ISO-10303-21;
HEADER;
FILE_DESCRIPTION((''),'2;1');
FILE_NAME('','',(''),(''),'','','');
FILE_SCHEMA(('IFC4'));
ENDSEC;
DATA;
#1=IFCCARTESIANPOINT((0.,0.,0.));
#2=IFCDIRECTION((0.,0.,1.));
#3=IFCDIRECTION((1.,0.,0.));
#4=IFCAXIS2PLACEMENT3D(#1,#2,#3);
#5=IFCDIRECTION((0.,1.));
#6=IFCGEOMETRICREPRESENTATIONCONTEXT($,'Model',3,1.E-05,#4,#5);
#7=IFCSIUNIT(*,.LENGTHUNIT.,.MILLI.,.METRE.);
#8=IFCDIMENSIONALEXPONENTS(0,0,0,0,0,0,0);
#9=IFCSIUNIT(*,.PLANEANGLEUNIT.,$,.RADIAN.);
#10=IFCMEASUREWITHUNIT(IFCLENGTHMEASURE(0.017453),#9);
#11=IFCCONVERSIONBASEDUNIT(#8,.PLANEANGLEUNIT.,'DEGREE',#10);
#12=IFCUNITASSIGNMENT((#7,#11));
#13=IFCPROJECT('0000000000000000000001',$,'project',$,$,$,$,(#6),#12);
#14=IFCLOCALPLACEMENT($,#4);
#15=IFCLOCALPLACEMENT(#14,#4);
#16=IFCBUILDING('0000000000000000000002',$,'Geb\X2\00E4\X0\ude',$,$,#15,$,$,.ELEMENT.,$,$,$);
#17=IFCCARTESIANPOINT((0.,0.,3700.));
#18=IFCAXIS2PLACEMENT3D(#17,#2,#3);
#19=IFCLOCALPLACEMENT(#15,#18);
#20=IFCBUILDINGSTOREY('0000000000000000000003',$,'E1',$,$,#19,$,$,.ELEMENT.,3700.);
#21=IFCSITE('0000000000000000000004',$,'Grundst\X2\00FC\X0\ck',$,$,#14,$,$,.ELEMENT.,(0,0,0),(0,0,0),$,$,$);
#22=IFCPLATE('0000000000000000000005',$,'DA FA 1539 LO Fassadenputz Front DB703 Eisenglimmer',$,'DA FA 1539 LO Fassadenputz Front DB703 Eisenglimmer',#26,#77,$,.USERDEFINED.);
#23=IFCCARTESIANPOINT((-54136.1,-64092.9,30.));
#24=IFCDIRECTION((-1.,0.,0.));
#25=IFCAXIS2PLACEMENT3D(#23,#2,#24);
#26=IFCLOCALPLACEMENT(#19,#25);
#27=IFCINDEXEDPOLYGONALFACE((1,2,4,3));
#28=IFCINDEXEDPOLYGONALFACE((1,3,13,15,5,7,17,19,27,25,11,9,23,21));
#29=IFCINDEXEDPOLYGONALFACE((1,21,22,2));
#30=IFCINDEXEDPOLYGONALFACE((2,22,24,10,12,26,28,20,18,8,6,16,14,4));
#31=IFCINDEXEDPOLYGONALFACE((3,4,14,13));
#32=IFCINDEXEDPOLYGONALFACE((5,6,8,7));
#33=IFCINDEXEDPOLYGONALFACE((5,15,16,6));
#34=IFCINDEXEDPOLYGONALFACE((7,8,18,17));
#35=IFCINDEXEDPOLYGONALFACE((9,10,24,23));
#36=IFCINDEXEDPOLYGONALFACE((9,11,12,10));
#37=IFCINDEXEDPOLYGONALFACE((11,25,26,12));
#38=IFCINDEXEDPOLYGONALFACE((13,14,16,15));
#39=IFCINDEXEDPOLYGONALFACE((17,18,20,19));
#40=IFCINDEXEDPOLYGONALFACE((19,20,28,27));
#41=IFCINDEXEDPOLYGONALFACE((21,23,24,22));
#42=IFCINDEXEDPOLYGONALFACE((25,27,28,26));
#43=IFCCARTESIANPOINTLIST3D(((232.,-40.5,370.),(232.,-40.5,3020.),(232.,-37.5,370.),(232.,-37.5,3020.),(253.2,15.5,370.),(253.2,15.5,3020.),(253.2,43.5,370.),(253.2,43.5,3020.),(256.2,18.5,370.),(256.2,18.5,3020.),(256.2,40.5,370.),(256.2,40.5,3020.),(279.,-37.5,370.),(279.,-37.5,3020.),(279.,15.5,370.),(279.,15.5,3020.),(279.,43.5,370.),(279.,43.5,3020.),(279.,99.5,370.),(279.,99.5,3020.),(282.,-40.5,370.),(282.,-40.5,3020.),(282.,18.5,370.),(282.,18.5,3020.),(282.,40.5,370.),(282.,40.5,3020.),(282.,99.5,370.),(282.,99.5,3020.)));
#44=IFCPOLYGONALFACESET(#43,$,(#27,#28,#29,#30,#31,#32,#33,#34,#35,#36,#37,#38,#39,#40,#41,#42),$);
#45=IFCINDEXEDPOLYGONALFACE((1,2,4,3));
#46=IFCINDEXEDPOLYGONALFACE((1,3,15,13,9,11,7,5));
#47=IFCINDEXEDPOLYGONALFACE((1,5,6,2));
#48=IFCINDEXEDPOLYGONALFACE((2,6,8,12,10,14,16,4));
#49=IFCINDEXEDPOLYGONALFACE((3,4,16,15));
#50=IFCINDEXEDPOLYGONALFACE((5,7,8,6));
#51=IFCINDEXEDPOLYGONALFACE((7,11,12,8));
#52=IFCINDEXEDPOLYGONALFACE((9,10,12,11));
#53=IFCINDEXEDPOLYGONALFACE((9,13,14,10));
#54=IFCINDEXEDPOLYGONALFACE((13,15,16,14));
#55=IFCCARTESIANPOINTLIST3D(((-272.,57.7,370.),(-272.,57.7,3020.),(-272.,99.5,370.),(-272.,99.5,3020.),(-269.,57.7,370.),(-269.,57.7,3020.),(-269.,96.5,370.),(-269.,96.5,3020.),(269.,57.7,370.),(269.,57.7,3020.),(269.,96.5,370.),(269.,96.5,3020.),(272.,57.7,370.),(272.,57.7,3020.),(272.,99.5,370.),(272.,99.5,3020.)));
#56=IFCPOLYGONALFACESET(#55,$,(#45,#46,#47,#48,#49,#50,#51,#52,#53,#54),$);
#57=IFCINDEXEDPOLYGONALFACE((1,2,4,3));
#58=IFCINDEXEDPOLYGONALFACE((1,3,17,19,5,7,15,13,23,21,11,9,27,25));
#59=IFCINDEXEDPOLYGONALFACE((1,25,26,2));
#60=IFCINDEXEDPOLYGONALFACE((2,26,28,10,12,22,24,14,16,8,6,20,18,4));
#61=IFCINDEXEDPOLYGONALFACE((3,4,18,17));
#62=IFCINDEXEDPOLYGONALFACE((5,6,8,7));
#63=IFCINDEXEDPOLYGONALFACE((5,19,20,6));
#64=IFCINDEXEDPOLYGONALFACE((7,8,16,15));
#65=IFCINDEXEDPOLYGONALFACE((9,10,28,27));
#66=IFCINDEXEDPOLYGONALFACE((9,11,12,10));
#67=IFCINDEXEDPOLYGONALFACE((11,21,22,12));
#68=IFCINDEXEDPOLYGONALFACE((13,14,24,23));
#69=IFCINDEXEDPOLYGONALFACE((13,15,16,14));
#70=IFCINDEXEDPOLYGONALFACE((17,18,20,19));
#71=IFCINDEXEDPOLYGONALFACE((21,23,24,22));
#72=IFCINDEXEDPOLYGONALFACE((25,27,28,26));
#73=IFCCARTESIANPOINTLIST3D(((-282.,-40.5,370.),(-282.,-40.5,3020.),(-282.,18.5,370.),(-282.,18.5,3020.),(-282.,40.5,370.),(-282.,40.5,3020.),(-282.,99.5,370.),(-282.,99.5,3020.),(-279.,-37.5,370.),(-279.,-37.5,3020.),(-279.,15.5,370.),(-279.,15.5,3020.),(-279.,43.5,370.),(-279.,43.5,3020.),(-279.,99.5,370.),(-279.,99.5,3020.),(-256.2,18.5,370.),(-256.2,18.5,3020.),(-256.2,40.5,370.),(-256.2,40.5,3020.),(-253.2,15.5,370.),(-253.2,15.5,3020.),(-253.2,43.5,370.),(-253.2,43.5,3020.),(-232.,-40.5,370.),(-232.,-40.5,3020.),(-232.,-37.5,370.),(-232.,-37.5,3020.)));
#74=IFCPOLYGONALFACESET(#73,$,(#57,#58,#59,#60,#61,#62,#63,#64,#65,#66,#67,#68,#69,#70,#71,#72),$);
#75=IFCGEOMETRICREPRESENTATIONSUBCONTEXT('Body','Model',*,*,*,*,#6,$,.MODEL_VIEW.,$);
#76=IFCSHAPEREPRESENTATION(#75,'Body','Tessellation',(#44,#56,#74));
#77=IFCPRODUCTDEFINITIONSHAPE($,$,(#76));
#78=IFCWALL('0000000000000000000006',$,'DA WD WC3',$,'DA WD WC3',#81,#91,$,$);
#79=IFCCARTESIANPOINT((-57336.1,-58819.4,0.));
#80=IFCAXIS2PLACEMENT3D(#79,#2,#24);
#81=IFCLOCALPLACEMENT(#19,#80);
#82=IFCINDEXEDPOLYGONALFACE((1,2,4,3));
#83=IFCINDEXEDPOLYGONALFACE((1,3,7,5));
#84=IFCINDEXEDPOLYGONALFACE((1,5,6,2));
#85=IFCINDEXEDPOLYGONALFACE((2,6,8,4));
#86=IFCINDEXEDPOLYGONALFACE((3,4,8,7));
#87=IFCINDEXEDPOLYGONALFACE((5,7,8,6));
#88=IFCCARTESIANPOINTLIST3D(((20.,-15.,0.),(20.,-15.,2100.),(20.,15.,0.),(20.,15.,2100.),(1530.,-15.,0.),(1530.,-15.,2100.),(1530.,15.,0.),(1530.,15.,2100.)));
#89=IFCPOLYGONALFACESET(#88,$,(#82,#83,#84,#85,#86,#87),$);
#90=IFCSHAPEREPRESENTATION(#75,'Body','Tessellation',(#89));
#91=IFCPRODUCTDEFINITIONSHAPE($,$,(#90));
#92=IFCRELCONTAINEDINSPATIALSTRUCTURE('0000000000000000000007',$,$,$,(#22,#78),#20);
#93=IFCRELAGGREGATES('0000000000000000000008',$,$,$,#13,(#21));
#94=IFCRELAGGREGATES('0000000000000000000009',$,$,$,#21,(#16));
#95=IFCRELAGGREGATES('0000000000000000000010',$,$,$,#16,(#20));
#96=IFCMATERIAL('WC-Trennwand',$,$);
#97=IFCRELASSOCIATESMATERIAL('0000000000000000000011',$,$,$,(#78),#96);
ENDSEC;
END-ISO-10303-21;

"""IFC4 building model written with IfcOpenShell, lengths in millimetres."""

from ifc_helpers import new_model, entity, si_unit, converted_unit, direction, frame, origin_with_axes, place, context, subcontext, project, spatial, line, indexed_curve, outline, extrude, source, transform, mapped, material, element, save


model = new_model("IFC4")

# Units and contexts
model_context = context("Model", 3, precision=1e-05, world=origin_with_axes(), true_north=direction((0.0, 1.0)))
body_context = subcontext(model_context, "Body", "Model", "MODEL_VIEW")
ifc_project = project(units=[si_unit("LENGTHUNIT", "METRE", prefix="MILLI"), converted_unit("PLANEANGLEUNIT", "DEGREE", entity("IfcLengthMeasure", 0.017453), si_unit("PLANEANGLEUNIT", "RADIAN"), dimensions=[0, 0, 0, 0, 0, 0, 0])], contexts=[model_context])

# Site, building, storey
site_placement = place(None, origin_with_axes())
site = spatial("IfcSite", under=ifc_project, at=site_placement, Name="Grundstück", CompositionType="ELEMENT", RefLatitude=(0, 0, 0), RefLongitude=(0, 0, 0))
building_placement = place(site_placement, origin_with_axes())
building = spatial("IfcBuilding", under=site, at=building_placement, Name="Gebäude", CompositionType="ELEMENT")
storey_placement = place(building_placement, frame((0.0, 0.0, 3700.0), z_axis=(0.0, 0.0, 1.0), x_axis=(1.0, 0.0, 0.0)))
storey = spatial("IfcBuildingStorey", under=building, at=storey_placement, Name="E1", CompositionType="ELEMENT", Elevation=3700.0)

# Plate
shared_shape_1 = source(origin_with_axes(), body_context, "Body", "SweptSolid", [
    extrude(outline(indexed_curve([(282.0, 99.5), (282.0, 40.5), (256.2, 40.5), (256.2, 18.5), (282.0, 18.5), (282.0, -40.5), (232.0, -40.5), (232.0, -37.5), (279.0, -37.5), (279.0, 15.5), (253.2, 15.5), (253.2, 43.5), (279.0, 43.5), (279.0, 99.5)], segments=[line(1, 2), line(2, 3), line(3, 4), line(4, 5), line(5, 6), line(6, 7), line(7, 8), line(8, 9), line(9, 10), line(10, 11), line(11, 12), line(12, 13), line(13, 14), line(14, 1)])), frame((0.0, 0.0, 370.0), z_axis=(0.0, 0.0, 1.0), x_axis=(1.0, 0.0, 0.0)), (0.0, 0.0, 1.0), 2650.0),
    extrude(outline(indexed_curve([(272.0, 99.5), (272.0, 57.7), (269.0, 57.7), (269.0, 96.5), (-269.0, 96.5), (-269.0, 57.7), (-272.0, 57.7), (-272.0, 99.5)], segments=[line(1, 2), line(2, 3), line(3, 4), line(4, 5), line(5, 6), line(6, 7), line(7, 8), line(8, 1)])), frame((0.0, 0.0, 370.0), z_axis=(0.0, 0.0, 1.0), x_axis=(1.0, 0.0, 0.0)), (0.0, 0.0, 1.0), 2650.0),
    extrude(outline(indexed_curve([(-282.0, 99.5), (-282.0, 40.5), (-256.2, 40.5), (-256.2, 18.5), (-282.0, 18.5), (-282.0, -40.5), (-232.0, -40.5), (-232.0, -37.5), (-279.0, -37.5), (-279.0, 15.5), (-253.2, 15.5), (-253.2, 43.5), (-279.0, 43.5), (-279.0, 99.5)], segments=[line(1, 2), line(2, 3), line(3, 4), line(4, 5), line(5, 6), line(6, 7), line(7, 8), line(8, 9), line(9, 10), line(10, 11), line(11, 12), line(12, 13), line(13, 14), line(14, 1)])), frame((0.0, 0.0, 370.0), z_axis=(0.0, 0.0, 1.0), x_axis=(1.0, 0.0, 0.0)), (0.0, 0.0, 1.0), 2650.0),
])
plate_1_placement = place(storey_placement, frame((-54136.1, -64092.9, 30.0), z_axis=(0.0, 0.0, 1.0), x_axis=(-1.0, 0.0, 0.0)))
element("IfcPlate", 1, at=plate_1_placement, inside=storey, Name="DA FA 1539 LO Fassadenputz Front DB703 Eisenglimmer", ObjectType="DA FA 1539 LO Fassadenputz Front DB703 Eisenglimmer", PredefinedType="USERDEFINED", context=body_context, shape_type="MappedRepresentation", body=[
    mapped(shared_shape_1, transform((0.0, 0.0, 0.0), x_axis=(1.0, 0.0, 0.0), y_axis=(0.0, 1.0, 0.0), z_axis=(0.0, 0.0, 1.0), scale=1.0)),
])

# Wall
ifc_material_1 = material(Name="WC-Trennwand")
wall_1_placement = place(storey_placement, frame((-57336.1, -58819.4, 0.0), z_axis=(0.0, 0.0, 1.0), x_axis=(-1.0, 0.0, 0.0)))
element("IfcWall", 2, at=wall_1_placement, inside=storey, material=ifc_material_1, Name="DA WD WC3", ObjectType="DA WD WC3", context=body_context, shape_type="SweptSolid", body=[
    extrude(outline(indexed_curve([(20.0, -15.0), (20.0, 15.0), (1530.0, 15.0), (1530.0, -15.0)], segments=[line(1, 2), line(2, 3), line(3, 4), line(4, 1)])), origin_with_axes(), (0.0, 0.0, 1.0), 2100.0),
])

save(model, "model.ifc")
